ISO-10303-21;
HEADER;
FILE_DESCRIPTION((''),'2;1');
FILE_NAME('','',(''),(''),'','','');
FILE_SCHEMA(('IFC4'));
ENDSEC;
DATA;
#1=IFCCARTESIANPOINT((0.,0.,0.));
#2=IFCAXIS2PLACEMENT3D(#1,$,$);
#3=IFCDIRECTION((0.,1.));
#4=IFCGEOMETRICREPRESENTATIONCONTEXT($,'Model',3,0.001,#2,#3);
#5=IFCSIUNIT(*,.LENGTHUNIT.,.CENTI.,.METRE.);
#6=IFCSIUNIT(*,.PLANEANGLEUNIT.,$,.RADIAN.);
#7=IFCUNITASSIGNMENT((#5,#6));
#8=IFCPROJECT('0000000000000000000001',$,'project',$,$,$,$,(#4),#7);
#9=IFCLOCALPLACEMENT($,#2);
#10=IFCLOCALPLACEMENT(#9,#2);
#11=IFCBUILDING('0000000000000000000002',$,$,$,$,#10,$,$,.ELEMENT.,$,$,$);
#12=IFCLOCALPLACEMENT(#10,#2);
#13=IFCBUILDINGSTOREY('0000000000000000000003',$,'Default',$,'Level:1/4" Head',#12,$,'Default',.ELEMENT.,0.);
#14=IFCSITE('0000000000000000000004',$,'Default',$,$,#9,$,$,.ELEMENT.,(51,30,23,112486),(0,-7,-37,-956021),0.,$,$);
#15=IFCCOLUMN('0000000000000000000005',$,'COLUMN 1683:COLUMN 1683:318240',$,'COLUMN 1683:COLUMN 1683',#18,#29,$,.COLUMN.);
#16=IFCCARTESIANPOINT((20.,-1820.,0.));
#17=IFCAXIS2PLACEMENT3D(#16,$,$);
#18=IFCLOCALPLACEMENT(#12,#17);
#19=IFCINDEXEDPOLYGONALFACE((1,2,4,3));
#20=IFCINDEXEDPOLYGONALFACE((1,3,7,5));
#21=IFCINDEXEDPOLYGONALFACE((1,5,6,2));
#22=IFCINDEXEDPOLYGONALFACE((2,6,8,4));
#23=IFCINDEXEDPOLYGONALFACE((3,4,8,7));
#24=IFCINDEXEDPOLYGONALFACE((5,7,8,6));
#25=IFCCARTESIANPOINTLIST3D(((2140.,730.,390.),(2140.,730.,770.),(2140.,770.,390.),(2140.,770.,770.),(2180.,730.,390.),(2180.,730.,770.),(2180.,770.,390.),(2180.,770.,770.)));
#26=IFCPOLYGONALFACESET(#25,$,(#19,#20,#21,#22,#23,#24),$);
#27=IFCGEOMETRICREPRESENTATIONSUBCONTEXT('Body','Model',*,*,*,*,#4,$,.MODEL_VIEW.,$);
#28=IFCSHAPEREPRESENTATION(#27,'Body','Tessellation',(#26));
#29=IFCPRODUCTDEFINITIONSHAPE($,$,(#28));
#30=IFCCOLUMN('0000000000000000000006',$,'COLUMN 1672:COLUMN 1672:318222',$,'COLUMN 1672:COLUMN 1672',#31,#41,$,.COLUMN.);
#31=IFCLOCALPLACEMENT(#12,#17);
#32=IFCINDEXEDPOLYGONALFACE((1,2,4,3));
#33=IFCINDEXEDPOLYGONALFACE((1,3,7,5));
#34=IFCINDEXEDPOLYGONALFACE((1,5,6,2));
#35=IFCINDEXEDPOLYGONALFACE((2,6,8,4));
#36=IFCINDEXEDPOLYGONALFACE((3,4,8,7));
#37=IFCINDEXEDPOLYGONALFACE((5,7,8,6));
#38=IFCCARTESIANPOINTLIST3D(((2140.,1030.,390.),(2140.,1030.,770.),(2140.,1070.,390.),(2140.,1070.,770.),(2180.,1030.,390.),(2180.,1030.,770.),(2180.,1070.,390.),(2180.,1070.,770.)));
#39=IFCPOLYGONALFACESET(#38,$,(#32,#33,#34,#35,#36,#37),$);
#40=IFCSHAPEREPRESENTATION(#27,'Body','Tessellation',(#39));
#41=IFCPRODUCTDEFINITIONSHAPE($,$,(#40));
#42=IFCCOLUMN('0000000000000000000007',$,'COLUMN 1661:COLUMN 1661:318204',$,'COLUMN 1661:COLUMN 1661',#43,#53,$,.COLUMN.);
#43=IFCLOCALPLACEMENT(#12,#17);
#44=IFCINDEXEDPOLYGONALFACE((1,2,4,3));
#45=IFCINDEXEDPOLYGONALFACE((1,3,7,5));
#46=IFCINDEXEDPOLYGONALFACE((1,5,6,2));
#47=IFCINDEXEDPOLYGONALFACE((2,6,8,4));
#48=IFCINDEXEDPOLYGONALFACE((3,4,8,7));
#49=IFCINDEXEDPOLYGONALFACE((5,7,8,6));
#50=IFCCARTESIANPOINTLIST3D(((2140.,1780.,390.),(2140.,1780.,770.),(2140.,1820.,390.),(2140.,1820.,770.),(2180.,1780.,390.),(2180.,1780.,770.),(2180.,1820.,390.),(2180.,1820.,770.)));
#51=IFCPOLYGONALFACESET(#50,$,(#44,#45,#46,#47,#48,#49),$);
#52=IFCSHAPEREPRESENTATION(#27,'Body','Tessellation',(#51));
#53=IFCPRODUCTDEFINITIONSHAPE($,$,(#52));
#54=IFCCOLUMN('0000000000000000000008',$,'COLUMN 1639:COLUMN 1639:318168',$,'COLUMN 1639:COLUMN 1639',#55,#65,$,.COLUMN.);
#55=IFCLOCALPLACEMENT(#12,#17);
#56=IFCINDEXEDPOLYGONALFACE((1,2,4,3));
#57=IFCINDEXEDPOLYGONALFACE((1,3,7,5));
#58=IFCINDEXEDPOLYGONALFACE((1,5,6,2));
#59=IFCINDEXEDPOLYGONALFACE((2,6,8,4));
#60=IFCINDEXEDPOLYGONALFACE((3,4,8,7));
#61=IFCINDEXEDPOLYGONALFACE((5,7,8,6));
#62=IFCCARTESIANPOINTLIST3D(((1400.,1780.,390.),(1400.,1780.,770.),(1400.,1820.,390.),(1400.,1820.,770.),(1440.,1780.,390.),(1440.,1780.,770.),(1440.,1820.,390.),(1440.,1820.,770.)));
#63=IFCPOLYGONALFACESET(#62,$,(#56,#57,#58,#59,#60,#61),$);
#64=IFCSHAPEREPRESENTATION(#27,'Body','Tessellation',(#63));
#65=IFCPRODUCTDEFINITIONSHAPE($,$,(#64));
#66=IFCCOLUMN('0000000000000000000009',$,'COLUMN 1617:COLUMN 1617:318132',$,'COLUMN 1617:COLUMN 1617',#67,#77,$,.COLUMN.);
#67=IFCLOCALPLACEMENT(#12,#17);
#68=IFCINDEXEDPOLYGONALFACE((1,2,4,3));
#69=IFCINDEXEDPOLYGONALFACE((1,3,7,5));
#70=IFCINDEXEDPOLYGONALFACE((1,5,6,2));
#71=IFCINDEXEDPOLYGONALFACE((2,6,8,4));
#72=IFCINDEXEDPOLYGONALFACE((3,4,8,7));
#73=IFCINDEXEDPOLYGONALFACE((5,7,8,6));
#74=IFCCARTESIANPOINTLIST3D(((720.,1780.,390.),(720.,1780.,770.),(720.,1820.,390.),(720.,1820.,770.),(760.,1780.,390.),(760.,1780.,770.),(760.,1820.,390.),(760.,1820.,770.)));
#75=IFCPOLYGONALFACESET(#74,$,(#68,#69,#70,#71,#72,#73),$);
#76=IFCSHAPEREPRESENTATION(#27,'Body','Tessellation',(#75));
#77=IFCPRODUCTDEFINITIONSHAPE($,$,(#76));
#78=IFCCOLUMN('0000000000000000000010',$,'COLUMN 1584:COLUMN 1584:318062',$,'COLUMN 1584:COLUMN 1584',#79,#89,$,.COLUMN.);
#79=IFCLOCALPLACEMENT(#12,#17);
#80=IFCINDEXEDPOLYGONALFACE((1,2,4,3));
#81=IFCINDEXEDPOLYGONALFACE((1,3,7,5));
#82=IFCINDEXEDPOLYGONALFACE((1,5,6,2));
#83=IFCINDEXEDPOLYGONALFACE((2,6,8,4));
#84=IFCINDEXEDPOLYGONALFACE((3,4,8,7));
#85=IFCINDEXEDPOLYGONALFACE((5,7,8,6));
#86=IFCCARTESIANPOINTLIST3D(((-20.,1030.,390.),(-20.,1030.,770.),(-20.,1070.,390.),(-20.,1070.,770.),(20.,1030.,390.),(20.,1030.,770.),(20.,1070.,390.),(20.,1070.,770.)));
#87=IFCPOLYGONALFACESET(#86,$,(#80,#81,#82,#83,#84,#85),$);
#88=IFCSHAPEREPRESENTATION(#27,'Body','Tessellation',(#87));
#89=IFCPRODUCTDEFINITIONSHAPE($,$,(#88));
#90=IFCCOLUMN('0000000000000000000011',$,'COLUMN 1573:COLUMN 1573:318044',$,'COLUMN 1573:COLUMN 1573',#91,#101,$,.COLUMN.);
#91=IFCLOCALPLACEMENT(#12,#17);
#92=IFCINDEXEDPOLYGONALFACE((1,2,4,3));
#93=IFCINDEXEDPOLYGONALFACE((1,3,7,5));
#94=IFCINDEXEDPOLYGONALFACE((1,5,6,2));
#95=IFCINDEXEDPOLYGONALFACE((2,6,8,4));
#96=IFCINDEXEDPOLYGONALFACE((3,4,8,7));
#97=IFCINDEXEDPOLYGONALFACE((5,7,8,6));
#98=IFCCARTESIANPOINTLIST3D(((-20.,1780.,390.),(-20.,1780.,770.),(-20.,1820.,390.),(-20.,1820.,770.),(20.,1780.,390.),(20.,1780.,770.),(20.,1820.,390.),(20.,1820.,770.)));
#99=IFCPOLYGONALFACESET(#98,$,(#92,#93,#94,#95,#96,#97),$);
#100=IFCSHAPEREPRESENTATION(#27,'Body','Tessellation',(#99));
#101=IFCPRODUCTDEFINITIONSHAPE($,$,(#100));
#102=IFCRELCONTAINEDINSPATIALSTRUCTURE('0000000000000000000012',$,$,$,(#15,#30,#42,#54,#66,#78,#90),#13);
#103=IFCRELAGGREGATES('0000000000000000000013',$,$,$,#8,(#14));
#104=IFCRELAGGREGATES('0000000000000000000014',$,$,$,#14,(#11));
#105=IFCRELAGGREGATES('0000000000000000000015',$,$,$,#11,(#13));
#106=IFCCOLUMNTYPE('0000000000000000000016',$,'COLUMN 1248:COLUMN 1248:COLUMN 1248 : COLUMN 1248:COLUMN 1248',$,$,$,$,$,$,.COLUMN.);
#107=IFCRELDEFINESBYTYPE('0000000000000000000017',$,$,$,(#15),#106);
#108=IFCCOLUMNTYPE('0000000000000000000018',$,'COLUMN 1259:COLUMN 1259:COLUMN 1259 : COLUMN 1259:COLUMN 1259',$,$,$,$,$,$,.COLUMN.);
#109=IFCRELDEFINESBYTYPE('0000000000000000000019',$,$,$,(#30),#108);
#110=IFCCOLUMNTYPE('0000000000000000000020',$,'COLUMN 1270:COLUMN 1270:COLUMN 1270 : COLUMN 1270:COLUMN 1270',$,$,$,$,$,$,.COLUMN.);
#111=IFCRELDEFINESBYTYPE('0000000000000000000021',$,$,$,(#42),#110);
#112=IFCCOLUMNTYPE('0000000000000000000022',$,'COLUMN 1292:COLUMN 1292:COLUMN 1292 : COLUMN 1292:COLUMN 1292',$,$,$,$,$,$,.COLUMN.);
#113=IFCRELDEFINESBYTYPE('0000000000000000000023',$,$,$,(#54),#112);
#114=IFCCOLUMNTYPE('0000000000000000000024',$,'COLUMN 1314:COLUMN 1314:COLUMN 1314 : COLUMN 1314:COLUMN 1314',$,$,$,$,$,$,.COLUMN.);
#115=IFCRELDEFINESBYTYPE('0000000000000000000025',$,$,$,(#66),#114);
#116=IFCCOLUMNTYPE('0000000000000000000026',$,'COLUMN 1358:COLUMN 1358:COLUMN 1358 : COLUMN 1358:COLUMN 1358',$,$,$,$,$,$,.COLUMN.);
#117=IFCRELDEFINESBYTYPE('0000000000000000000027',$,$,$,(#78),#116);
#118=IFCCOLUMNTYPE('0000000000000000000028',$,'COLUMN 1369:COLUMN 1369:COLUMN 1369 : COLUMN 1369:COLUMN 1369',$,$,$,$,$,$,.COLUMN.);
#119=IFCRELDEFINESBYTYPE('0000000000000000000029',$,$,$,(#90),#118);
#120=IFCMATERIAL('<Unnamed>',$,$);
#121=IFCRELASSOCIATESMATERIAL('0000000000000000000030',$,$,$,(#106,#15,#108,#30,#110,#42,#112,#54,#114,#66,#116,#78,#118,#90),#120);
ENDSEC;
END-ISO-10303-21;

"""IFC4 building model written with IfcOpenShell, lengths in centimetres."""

from ifc_helpers import new_model, si_unit, direction, frame, frame_2d, origin, origin_2d_with_axis, place, context, subcontext, project, spatial, polyline, segment, composite_curve, rectangle, outline, extrude, source, transform, mapped, material, material_profile, profile_set, profile_usage, type_object, type_shapes, element, save


model = new_model("IFC4")

# Units and contexts
model_context = context("Model", 3, precision=0.001, world=origin(), true_north=direction((0.0, 1.0)))
body_context = subcontext(model_context, "Body", "Model", "MODEL_VIEW")
ifc_project = project(units=[si_unit("LENGTHUNIT", "METRE", prefix="CENTI"), si_unit("PLANEANGLEUNIT", "RADIAN")], contexts=[model_context])

# Site, building, storey
site_placement = place(None, origin())
site = spatial("IfcSite", under=ifc_project, at=site_placement, Name="Default", CompositionType="ELEMENT", RefLatitude=(51, 30, 23, 112486), RefLongitude=(0, -7, -37, -956021), RefElevation=0.0)
building_placement = place(site_placement, origin())
building = spatial("IfcBuilding", under=site, at=building_placement, CompositionType="ELEMENT")
storey_placement = place(building_placement, origin())
storey = spatial("IfcBuildingStorey", under=building, at=storey_placement, Name="Default", ObjectType="Level:1/4\" Head", LongName="Default", CompositionType="ELEMENT", Elevation=0.0)

# Columns
ifc_material_1 = material(Name="<Unnamed>")
ifc_material_profile_1 = material_profile(ifc_material_1, outline(composite_curve([segment(polyline([(2140.0, 730.0, 390.0), (2140.0, 770.0, 390.0)]), True, "CONTINUOUS"), segment(polyline([(2140.0, 770.0, 390.0), (2180.0, 770.0, 390.0)]), True, "CONTINUOUS"), segment(polyline([(2180.0, 770.0, 390.0), (2180.0, 730.0, 390.0)]), True, "CONTINUOUS"), segment(polyline([(2180.0, 730.0, 390.0), (2140.0, 730.0, 390.0)]), True, "CONTINUOUS")], self_intersect=False), kind="CURVE"), Name="COLUMN 1248 : COLUMN 1248:COLUMN 1248")
ifc_profile_set_1 = profile_set([ifc_material_profile_1], Name="COLUMN 1248 : COLUMN 1248:COLUMN 1248")
ifc_profile_usage_1 = profile_usage(ifc_profile_set_1)
column_type_1 = type_object("IfcColumnType", Name="COLUMN 1248:COLUMN 1248:COLUMN 1248 : COLUMN 1248:COLUMN 1248", PredefinedType="COLUMN", material=ifc_profile_set_1)
shared_shape_1 = source(origin(), body_context, "Body", "SweptSolid", [
    extrude(rectangle(XDim=40.0, YDim=40.0, at=frame_2d((0.0, 0.0), x_axis=(1.0, 0.0))), frame((2160.0, 750.0, 390.0), z_axis=(0.0, 0.0, 1.0), x_axis=(0.0, -1.0, 0.0)), (0.0, 0.0, 1.0), 380.0),
])
type_shapes(column_type_1, [shared_shape_1])
column_1_placement = place(storey_placement, frame((20.0, -1820.0, 0.0)))
element("IfcColumn", 1, at=column_1_placement, inside=storey, type_object=column_type_1, material=ifc_profile_usage_1, Name="COLUMN 1683:COLUMN 1683:318240", ObjectType="COLUMN 1683:COLUMN 1683", PredefinedType="COLUMN", context=body_context, shape_type="MappedRepresentation", body=[
    mapped(shared_shape_1, transform((0.0, 0.0, 0.0), scale=1.0)),
])
ifc_material_profile_2 = material_profile(ifc_material_1, outline(composite_curve([segment(polyline([(2140.0, 1030.0, 770.0), (2180.0, 1030.0, 770.0)]), True, "CONTINUOUS"), segment(polyline([(2180.0, 1030.0, 770.0), (2180.0, 1070.0, 770.0)]), True, "CONTINUOUS"), segment(polyline([(2180.0, 1070.0, 770.0), (2140.0, 1070.0, 770.0)]), True, "CONTINUOUS"), segment(polyline([(2140.0, 1070.0, 770.0), (2140.0, 1030.0, 770.0)]), True, "CONTINUOUS")], self_intersect=False), kind="CURVE"), Name="COLUMN 1259 : COLUMN 1259:COLUMN 1259")
ifc_profile_set_2 = profile_set([ifc_material_profile_2], Name="COLUMN 1259 : COLUMN 1259:COLUMN 1259")
ifc_profile_usage_2 = profile_usage(ifc_profile_set_2)
column_type_2 = type_object("IfcColumnType", Name="COLUMN 1259:COLUMN 1259:COLUMN 1259 : COLUMN 1259:COLUMN 1259", PredefinedType="COLUMN", material=ifc_profile_set_2)
shared_shape_2 = source(origin(), body_context, "Body", "SweptSolid", [
    extrude(rectangle(XDim=40.0, YDim=40.0, at=frame_2d((0.0, 0.0), x_axis=(1.0, 0.0))), frame((2160.0, 1050.0, 390.0), z_axis=(0.0, 0.0, 1.0), x_axis=(0.0, -1.0, 0.0)), (0.0, 0.0, 1.0), 380.0),
])
type_shapes(column_type_2, [shared_shape_2])
column_2_placement = place(storey_placement, frame((20.0, -1820.0, 0.0)))
element("IfcColumn", 2, at=column_2_placement, inside=storey, type_object=column_type_2, material=ifc_profile_usage_2, Name="COLUMN 1672:COLUMN 1672:318222", ObjectType="COLUMN 1672:COLUMN 1672", PredefinedType="COLUMN", context=body_context, shape_type="MappedRepresentation", body=[
    mapped(shared_shape_2, transform((0.0, 0.0, 0.0), scale=1.0)),
])
ifc_material_profile_3 = material_profile(ifc_material_1, outline(composite_curve([segment(polyline([(2140.0, 1780.0, 390.0), (2140.0, 1820.0, 390.0)]), True, "CONTINUOUS"), segment(polyline([(2140.0, 1820.0, 390.0), (2180.0, 1820.0, 390.0)]), True, "CONTINUOUS"), segment(polyline([(2180.0, 1820.0, 390.0), (2180.0, 1780.0, 390.0)]), True, "CONTINUOUS"), segment(polyline([(2180.0, 1780.0, 390.0), (2140.0, 1780.0, 390.0)]), True, "CONTINUOUS")], self_intersect=False), kind="CURVE"), Name="COLUMN 1270 : COLUMN 1270:COLUMN 1270")
ifc_profile_set_3 = profile_set([ifc_material_profile_3], Name="COLUMN 1270 : COLUMN 1270:COLUMN 1270")
ifc_profile_usage_3 = profile_usage(ifc_profile_set_3)
column_type_3 = type_object("IfcColumnType", Name="COLUMN 1270:COLUMN 1270:COLUMN 1270 : COLUMN 1270:COLUMN 1270", PredefinedType="COLUMN", material=ifc_profile_set_3)
shared_shape_3 = source(origin(), body_context, "Body", "SweptSolid", [
    extrude(rectangle(XDim=40.0, YDim=40.0, at=frame_2d((0.0, 0.0), x_axis=(1.0, 0.0))), frame((2160.0, 1800.0, 390.0), z_axis=(0.0, 0.0, 1.0), x_axis=(0.0, -1.0, 0.0)), (0.0, 0.0, 1.0), 380.0),
])
type_shapes(column_type_3, [shared_shape_3])
column_3_placement = place(storey_placement, frame((20.0, -1820.0, 0.0)))
element("IfcColumn", 3, at=column_3_placement, inside=storey, type_object=column_type_3, material=ifc_profile_usage_3, Name="COLUMN 1661:COLUMN 1661:318204", ObjectType="COLUMN 1661:COLUMN 1661", PredefinedType="COLUMN", context=body_context, shape_type="MappedRepresentation", body=[
    mapped(shared_shape_3, transform((0.0, 0.0, 0.0), scale=1.0)),
])
ifc_material_profile_4 = material_profile(ifc_material_1, outline(composite_curve([segment(polyline([(1400.0, 1780.0, 770.0), (1440.0, 1780.0, 770.0)]), True, "CONTINUOUS"), segment(polyline([(1440.0, 1780.0, 770.0), (1440.0, 1820.0, 770.0)]), True, "CONTINUOUS"), segment(polyline([(1440.0, 1820.0, 770.0), (1400.0, 1820.0, 770.0)]), True, "CONTINUOUS"), segment(polyline([(1400.0, 1820.0, 770.0), (1400.0, 1780.0, 770.0)]), True, "CONTINUOUS")], self_intersect=False), kind="CURVE"), Name="COLUMN 1292 : COLUMN 1292:COLUMN 1292")
ifc_profile_set_4 = profile_set([ifc_material_profile_4], Name="COLUMN 1292 : COLUMN 1292:COLUMN 1292")
ifc_profile_usage_4 = profile_usage(ifc_profile_set_4)
column_type_4 = type_object("IfcColumnType", Name="COLUMN 1292:COLUMN 1292:COLUMN 1292 : COLUMN 1292:COLUMN 1292", PredefinedType="COLUMN", material=ifc_profile_set_4)
shared_shape_4 = source(origin(), body_context, "Body", "SweptSolid", [
    extrude(rectangle(XDim=40.0, YDim=40.0, at=origin_2d_with_axis()), frame((1420.0, 1800.0, 390.0), z_axis=(0.0, 0.0, 1.0), x_axis=(0.0, -1.0, 0.0)), (0.0, 0.0, 1.0), 380.0),
])
type_shapes(column_type_4, [shared_shape_4])
column_4_placement = place(storey_placement, frame((20.0, -1820.0, 0.0)))
element("IfcColumn", 4, at=column_4_placement, inside=storey, type_object=column_type_4, material=ifc_profile_usage_4, Name="COLUMN 1639:COLUMN 1639:318168", ObjectType="COLUMN 1639:COLUMN 1639", PredefinedType="COLUMN", context=body_context, shape_type="MappedRepresentation", body=[
    mapped(shared_shape_4, transform((0.0, 0.0, 0.0), scale=1.0)),
])
ifc_material_profile_5 = material_profile(ifc_material_1, outline(composite_curve([segment(polyline([(720.0, 1780.0, 390.0), (720.0, 1820.0, 390.0)]), True, "CONTINUOUS"), segment(polyline([(720.0, 1820.0, 390.0), (760.0, 1820.0, 390.0)]), True, "CONTINUOUS"), segment(polyline([(760.0, 1820.0, 390.0), (760.0, 1780.0, 390.0)]), True, "CONTINUOUS"), segment(polyline([(760.0, 1780.0, 390.0), (720.0, 1780.0, 390.0)]), True, "CONTINUOUS")], self_intersect=False), kind="CURVE"), Name="COLUMN 1314 : COLUMN 1314:COLUMN 1314")
ifc_profile_set_5 = profile_set([ifc_material_profile_5], Name="COLUMN 1314 : COLUMN 1314:COLUMN 1314")
ifc_profile_usage_5 = profile_usage(ifc_profile_set_5)
column_type_5 = type_object("IfcColumnType", Name="COLUMN 1314:COLUMN 1314:COLUMN 1314 : COLUMN 1314:COLUMN 1314", PredefinedType="COLUMN", material=ifc_profile_set_5)
shared_shape_5 = source(origin(), body_context, "Body", "SweptSolid", [
    extrude(rectangle(XDim=40.0, YDim=40.0, at=origin_2d_with_axis()), frame((740.0, 1800.0, 390.0), z_axis=(0.0, 0.0, 1.0), x_axis=(0.0, -1.0, 0.0)), (0.0, 0.0, 1.0), 380.0),
])
type_shapes(column_type_5, [shared_shape_5])
column_5_placement = place(storey_placement, frame((20.0, -1820.0, 0.0)))
element("IfcColumn", 5, at=column_5_placement, inside=storey, type_object=column_type_5, material=ifc_profile_usage_5, Name="COLUMN 1617:COLUMN 1617:318132", ObjectType="COLUMN 1617:COLUMN 1617", PredefinedType="COLUMN", context=body_context, shape_type="MappedRepresentation", body=[
    mapped(shared_shape_5, transform((0.0, 0.0, 0.0), scale=1.0)),
])
ifc_material_profile_6 = material_profile(ifc_material_1, outline(composite_curve([segment(polyline([(-20.0, 1030.0, 390.0), (-20.0, 1070.0, 390.0)]), True, "CONTINUOUS"), segment(polyline([(-20.0, 1070.0, 390.0), (20.0, 1070.0, 390.0)]), True, "CONTINUOUS"), segment(polyline([(20.0, 1070.0, 390.0), (20.0, 1030.0, 390.0)]), True, "CONTINUOUS"), segment(polyline([(20.0, 1030.0, 390.0), (-20.0, 1030.0, 390.0)]), True, "CONTINUOUS")], self_intersect=False), kind="CURVE"), Name="COLUMN 1358 : COLUMN 1358:COLUMN 1358")
ifc_profile_set_6 = profile_set([ifc_material_profile_6], Name="COLUMN 1358 : COLUMN 1358:COLUMN 1358")
ifc_profile_usage_6 = profile_usage(ifc_profile_set_6)
column_type_6 = type_object("IfcColumnType", Name="COLUMN 1358:COLUMN 1358:COLUMN 1358 : COLUMN 1358:COLUMN 1358", PredefinedType="COLUMN", material=ifc_profile_set_6)
shared_shape_6 = source(origin(), body_context, "Body", "SweptSolid", [
    extrude(rectangle(XDim=40.0, YDim=40.0, at=origin_2d_with_axis()), frame((0.0, 1050.0, 390.0), z_axis=(0.0, 0.0, 1.0), x_axis=(0.0, -1.0, 0.0)), (0.0, 0.0, 1.0), 380.0),
])
type_shapes(column_type_6, [shared_shape_6])
column_6_placement = place(storey_placement, frame((20.0, -1820.0, 0.0)))
element("IfcColumn", 6, at=column_6_placement, inside=storey, type_object=column_type_6, material=ifc_profile_usage_6, Name="COLUMN 1584:COLUMN 1584:318062", ObjectType="COLUMN 1584:COLUMN 1584", PredefinedType="COLUMN", context=body_context, shape_type="MappedRepresentation", body=[
    mapped(shared_shape_6, transform((0.0, 0.0, 0.0), scale=1.0)),
])
ifc_material_profile_7 = material_profile(ifc_material_1, outline(composite_curve([segment(polyline([(-20.0, 1780.0, 390.0), (-20.0, 1820.0, 390.0)]), True, "CONTINUOUS"), segment(polyline([(-20.0, 1820.0, 390.0), (20.0, 1820.0, 390.0)]), True, "CONTINUOUS"), segment(polyline([(20.0, 1820.0, 390.0), (20.0, 1780.0, 390.0)]), True, "CONTINUOUS"), segment(polyline([(20.0, 1780.0, 390.0), (-20.0, 1780.0, 390.0)]), True, "CONTINUOUS")], self_intersect=False), kind="CURVE"), Name="COLUMN 1369 : COLUMN 1369:COLUMN 1369")
ifc_profile_set_7 = profile_set([ifc_material_profile_7], Name="COLUMN 1369 : COLUMN 1369:COLUMN 1369")
ifc_profile_usage_7 = profile_usage(ifc_profile_set_7)
column_type_7 = type_object("IfcColumnType", Name="COLUMN 1369:COLUMN 1369:COLUMN 1369 : COLUMN 1369:COLUMN 1369", PredefinedType="COLUMN", material=ifc_profile_set_7)
shared_shape_7 = source(origin(), body_context, "Body", "SweptSolid", [
    extrude(rectangle(XDim=40.0, YDim=40.0, at=origin_2d_with_axis()), frame((0.0, 1800.0, 390.0), z_axis=(0.0, 0.0, 1.0), x_axis=(0.0, -1.0, 0.0)), (0.0, 0.0, 1.0), 380.0),
])
type_shapes(column_type_7, [shared_shape_7])
column_7_placement = place(storey_placement, frame((20.0, -1820.0, 0.0)))
element("IfcColumn", 7, at=column_7_placement, inside=storey, type_object=column_type_7, material=ifc_profile_usage_7, Name="COLUMN 1573:COLUMN 1573:318044", ObjectType="COLUMN 1573:COLUMN 1573", PredefinedType="COLUMN", context=body_context, shape_type="MappedRepresentation", body=[
    mapped(shared_shape_7, transform((0.0, 0.0, 0.0), scale=1.0)),
])

save(model, "model.ifc")
